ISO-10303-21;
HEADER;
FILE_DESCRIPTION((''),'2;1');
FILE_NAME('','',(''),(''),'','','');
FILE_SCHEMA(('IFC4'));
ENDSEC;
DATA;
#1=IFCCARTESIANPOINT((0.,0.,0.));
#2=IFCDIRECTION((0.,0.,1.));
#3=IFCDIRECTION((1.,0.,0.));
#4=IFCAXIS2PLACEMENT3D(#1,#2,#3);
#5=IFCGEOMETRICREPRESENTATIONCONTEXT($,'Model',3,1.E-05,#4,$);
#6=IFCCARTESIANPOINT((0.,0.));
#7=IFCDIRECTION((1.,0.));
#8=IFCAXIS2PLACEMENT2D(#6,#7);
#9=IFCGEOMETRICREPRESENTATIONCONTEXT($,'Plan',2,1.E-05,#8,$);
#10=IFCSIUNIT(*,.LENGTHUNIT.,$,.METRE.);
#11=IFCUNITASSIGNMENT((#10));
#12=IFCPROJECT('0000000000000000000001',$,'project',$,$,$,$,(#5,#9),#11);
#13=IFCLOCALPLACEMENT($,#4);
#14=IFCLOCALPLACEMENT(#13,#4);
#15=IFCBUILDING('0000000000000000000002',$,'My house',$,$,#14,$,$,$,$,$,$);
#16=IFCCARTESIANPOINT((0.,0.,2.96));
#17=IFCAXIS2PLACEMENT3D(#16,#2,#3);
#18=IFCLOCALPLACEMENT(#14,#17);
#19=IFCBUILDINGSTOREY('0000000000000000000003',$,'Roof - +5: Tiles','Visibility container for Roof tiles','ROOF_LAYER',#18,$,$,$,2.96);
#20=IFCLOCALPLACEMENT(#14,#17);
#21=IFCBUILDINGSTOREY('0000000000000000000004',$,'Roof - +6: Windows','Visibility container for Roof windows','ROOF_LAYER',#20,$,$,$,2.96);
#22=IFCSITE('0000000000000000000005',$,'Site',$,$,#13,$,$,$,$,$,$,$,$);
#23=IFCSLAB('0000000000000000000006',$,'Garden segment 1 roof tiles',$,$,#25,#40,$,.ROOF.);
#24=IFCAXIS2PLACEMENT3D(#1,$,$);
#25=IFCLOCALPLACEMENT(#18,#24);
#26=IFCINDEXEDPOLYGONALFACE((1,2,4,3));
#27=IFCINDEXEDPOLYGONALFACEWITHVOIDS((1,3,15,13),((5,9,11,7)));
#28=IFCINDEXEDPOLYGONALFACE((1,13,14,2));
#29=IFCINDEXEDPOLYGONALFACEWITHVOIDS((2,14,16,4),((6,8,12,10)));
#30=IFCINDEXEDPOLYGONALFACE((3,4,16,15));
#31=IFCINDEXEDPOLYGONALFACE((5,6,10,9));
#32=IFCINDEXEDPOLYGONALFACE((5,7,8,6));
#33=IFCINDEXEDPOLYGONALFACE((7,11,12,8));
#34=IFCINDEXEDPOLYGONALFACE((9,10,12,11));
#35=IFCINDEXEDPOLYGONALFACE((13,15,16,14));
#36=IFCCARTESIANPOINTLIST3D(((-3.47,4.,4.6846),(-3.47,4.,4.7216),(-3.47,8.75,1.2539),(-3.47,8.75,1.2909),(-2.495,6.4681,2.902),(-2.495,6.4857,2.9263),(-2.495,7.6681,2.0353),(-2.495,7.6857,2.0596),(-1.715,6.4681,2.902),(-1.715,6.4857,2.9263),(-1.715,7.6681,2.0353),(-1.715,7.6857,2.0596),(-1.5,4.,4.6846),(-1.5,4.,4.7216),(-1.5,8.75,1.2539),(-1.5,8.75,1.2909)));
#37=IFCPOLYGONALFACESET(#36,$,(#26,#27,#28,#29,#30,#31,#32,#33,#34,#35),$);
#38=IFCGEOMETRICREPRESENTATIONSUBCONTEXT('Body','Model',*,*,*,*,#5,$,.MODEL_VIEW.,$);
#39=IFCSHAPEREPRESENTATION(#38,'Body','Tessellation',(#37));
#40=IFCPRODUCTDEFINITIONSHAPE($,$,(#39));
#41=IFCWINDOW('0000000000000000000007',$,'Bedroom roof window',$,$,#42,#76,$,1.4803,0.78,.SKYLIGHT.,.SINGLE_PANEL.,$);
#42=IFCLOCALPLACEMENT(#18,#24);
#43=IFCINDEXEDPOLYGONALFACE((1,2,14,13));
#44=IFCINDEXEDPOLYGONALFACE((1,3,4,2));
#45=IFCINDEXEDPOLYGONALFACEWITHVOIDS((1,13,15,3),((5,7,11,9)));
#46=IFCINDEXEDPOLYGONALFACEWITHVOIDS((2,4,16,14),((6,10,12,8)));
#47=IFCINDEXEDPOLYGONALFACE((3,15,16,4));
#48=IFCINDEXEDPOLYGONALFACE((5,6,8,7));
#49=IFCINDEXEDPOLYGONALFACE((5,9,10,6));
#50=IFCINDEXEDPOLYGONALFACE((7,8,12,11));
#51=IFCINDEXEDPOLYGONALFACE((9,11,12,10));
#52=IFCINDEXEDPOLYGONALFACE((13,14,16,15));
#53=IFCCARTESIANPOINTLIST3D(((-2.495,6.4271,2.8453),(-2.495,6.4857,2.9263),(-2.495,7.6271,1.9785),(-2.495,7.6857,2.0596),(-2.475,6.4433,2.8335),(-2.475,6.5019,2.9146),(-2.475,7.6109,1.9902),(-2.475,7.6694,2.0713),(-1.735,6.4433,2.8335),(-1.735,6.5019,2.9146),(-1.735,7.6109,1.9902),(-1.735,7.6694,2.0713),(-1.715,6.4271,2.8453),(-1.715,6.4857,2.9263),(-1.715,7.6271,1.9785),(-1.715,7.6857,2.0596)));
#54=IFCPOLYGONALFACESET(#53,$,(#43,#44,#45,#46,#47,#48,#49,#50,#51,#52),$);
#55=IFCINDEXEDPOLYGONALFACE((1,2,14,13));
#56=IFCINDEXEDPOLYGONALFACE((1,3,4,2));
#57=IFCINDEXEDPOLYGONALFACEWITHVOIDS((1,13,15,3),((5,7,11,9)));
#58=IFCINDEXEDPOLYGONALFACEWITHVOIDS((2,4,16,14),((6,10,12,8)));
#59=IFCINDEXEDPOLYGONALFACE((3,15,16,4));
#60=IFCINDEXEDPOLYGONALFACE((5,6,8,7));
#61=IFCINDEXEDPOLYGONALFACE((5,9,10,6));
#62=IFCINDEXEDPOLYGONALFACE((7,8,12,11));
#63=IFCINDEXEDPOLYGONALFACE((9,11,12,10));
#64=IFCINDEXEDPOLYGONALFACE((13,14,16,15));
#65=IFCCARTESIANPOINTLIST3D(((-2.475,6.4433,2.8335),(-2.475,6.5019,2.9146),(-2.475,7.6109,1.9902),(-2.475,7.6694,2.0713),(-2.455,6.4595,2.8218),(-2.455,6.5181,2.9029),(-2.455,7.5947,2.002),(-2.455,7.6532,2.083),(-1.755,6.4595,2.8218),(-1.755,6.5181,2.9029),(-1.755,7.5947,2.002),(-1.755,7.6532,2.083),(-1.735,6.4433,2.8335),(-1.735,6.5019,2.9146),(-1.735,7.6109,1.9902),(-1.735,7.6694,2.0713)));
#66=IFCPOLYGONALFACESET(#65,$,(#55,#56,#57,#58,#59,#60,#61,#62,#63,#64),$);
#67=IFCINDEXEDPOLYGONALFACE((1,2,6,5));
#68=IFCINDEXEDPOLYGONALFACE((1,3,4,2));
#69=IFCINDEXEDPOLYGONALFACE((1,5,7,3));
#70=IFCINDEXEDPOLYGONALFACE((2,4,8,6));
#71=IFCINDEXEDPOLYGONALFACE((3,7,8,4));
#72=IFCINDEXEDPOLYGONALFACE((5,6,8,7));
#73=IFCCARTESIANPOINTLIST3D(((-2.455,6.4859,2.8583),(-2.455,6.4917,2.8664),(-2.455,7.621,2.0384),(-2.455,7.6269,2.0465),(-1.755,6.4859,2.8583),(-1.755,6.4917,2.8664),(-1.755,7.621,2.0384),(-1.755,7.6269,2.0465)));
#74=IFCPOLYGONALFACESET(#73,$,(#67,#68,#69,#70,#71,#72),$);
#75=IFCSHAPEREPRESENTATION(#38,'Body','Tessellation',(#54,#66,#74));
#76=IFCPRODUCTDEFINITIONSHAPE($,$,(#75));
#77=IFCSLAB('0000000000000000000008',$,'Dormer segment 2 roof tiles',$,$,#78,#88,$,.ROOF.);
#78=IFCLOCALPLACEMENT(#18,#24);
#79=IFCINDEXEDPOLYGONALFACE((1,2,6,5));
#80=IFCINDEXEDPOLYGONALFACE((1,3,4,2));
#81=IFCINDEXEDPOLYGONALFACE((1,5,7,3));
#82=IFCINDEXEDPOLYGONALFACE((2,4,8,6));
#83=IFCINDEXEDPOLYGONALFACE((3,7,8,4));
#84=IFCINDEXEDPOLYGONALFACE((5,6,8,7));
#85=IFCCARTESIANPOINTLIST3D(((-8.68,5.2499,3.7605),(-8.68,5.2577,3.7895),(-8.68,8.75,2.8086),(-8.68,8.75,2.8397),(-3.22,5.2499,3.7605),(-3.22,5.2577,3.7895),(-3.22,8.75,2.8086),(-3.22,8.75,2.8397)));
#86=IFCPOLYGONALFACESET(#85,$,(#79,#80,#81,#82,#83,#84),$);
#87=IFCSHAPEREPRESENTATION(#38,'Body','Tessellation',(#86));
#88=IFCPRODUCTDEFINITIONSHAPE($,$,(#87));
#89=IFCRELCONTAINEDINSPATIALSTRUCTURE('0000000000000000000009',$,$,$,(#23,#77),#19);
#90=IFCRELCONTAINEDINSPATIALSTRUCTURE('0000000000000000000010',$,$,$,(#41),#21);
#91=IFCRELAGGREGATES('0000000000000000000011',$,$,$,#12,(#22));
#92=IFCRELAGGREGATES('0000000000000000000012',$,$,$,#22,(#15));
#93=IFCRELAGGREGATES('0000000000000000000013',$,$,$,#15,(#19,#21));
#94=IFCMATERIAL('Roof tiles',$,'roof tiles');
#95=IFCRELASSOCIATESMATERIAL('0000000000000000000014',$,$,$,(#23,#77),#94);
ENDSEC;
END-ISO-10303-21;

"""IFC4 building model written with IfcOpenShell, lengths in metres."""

from ifc_helpers import new_model, si_unit, frame, origin_with_axes, origin_2d_with_axis, place, context, subcontext, project, spatial, line, indexed_curve, outline, extrude, clip, halfspace, source, transform, mapped, material, element, fill, save


model = new_model("IFC4")

# Units and contexts
model_context = context("Model", 3, precision=1e-05, world=origin_with_axes())
plan_context = context("Plan", 2, precision=1e-05, world=origin_2d_with_axis())
body_context = subcontext(model_context, "Body", "Model", "MODEL_VIEW")
ifc_project = project(units=[si_unit("LENGTHUNIT", "METRE")], contexts=[model_context, plan_context])

# Site, building, storey
site_placement = place(None, origin_with_axes())
site = spatial("IfcSite", under=ifc_project, at=site_placement, Name="Site")
building_placement = place(site_placement, origin_with_axes())
building = spatial("IfcBuilding", under=site, at=building_placement, Name="My house")
storey_1_placement = place(building_placement, frame((0.0, 0.0, 2.96), z_axis=(0.0, 0.0, 1.0), x_axis=(1.0, 0.0, 0.0)))
storey_1 = spatial("IfcBuildingStorey", under=building, at=storey_1_placement, Name="Roof - +5: Tiles", Description="Visibility container for Roof tiles", ObjectType="ROOF_LAYER", Elevation=2.96)

# Shared definitions
ifc_material = material(Name="Roof tiles", Category="roof tiles")

# Slab, opening
shared_shape_1 = source(origin_with_axes(), body_context, "Body", "Clipping", [
    clip(clip(extrude(outline(indexed_curve([(1.5, -3.0), (3.47, -3.0), (3.47, 10.0), (1.5, 10.0)])), None, (0.0, 0.0, 1.0), 0.03), halfspace(frame((0.0, 2.8266, -6.1972), z_axis=(0.0, -0.810664, -0.585512), x_axis=(-1.0, 0.0, 0.0)), False)), halfspace(frame((0.0, 6.6773, -3.416), z_axis=(0.0, 0.810664, 0.585512), x_axis=(1.0, 0.0, 0.0)), False)),
])
slab_1_placement = place(storey_1_placement, frame((0.0, 5.3371, 3.7189), z_axis=(0.0, 0.585512, 0.810664), x_axis=(1.0, 0.0, 0.0)))
slab_1 = element("IfcSlab", 1, at=slab_1_placement, inside=storey_1, material=ifc_material, Name="Garden segment 1 roof tiles", PredefinedType="ROOF", context=body_context, shape_type="MappedRepresentation", body=[
    mapped(shared_shape_1, transform((0.0, 0.0, 0.0), x_axis=(-1.0, 0.0, 0.0), y_axis=(0.0, 1.0, 0.0), z_axis=(0.0, 0.0, 1.0), scale=1.0)),
])
shared_shape_2 = source(origin_with_axes(), body_context, "Body", "SweptSolid", [
    extrude(outline(indexed_curve([(1.715, 1.3952), (2.495, 1.3952), (2.495, 2.8754), (1.715, 2.8754)])), None, (0.0, 0.0, 1.0), 0.13),
])
opening_placement = place(slab_1_placement, frame((0.0, 0.0, -0.05), z_axis=(0.0, 0.0, 1.0), x_axis=(1.0, 0.0, 0.0)))
opening = element("IfcOpeningElement", 2, at=opening_placement, cuts=slab_1, ObjectType="ROOF_OPENING", PredefinedType="OPENING", context=body_context, shape_type="MappedRepresentation", body=[
    mapped(shared_shape_2, transform((0.0, 0.0, 0.0), x_axis=(-1.0, 0.0, 0.0), y_axis=(0.0, 1.0, 0.0), z_axis=(0.0, 0.0, 1.0), scale=1.0)),
])

# Shared definitions
storey_2_placement = place(building_placement, frame((0.0, 0.0, 2.96), z_axis=(0.0, 0.0, 1.0), x_axis=(1.0, 0.0, 0.0)))
storey_2 = spatial("IfcBuildingStorey", under=building, at=storey_2_placement, Name="Roof - +6: Windows", Description="Visibility container for Roof windows", ObjectType="ROOF_LAYER", Elevation=2.96)

# Window
shared_shape_3 = source(origin_with_axes(), body_context, "Body", "SweptSolid", [
    extrude(outline(indexed_curve([(0.0, 0.0), (0.78, 0.0), (0.78, 1.4803), (0.0, 1.4803)], segments=[line(1, 2, 3, 4, 1)]), holes=[indexed_curve([(0.02, 0.02), (0.76, 0.02), (0.76, 1.4603), (0.02, 1.4603)], segments=[line(1, 2, 3, 4, 1)])]), frame((0.0, 0.0, 0.0), z_axis=(0.0, -1.0, 0.0), x_axis=(1.0, 0.0, 0.0)), (0.0, 0.0, -1.0), 0.1),
    extrude(outline(indexed_curve([(0.0, 0.0), (0.74, 0.0), (0.74, 1.4403), (0.0, 1.4403)], segments=[line(1, 2, 3, 4, 1)]), holes=[indexed_curve([(0.02, 0.02), (0.72, 0.02), (0.72, 1.4203), (0.02, 1.4203)], segments=[line(1, 2, 3, 4, 1)])]), frame((0.02, 0.0, 0.02), z_axis=(0.0, -1.0, 0.0), x_axis=(1.0, 0.0, 0.0)), (0.0, 0.0, -1.0), 0.1),
    extrude(outline(indexed_curve([(0.02, 0.02), (0.72, 0.02), (0.72, 1.4203), (0.02, 1.4203)], segments=[line(1, 2, 3, 4, 1)])), frame((0.02, 0.045, 0.02), z_axis=(0.0, -1.0, 0.0), x_axis=(1.0, 0.0, 0.0)), (0.0, 0.0, -1.0), 0.01),
])
window_placement = place(opening_placement, frame((-1.715, 1.3952, 0.08), z_axis=(0.0, 1.0, 0.0), x_axis=(1.0, 0.0, 0.0)))
window = element("IfcWindow", 3, at=window_placement, inside=storey_2, Name="Bedroom roof window", OverallHeight=1.4803, OverallWidth=0.78, PartitioningType="SINGLE_PANEL", PredefinedType="SKYLIGHT", context=body_context, shape_type="MappedRepresentation", body=[
    mapped(shared_shape_3, transform((0.0, 0.0, 0.0), x_axis=(-1.0, 0.0, 0.0), y_axis=(0.0, 1.0, 0.0), z_axis=(0.0, 0.0, 1.0), scale=1.0)),
])
fill(opening, window)

# Slab
shared_shape_4 = source(origin_with_axes(), body_context, "Body", "Clipping", [
    clip(clip(extrude(outline(indexed_curve([(3.22, 0.0), (8.68, 0.0), (8.68, 7.0), (3.22, 7.0)])), None, (0.0, 0.0, 1.0), 0.03), halfspace(frame((0.0, 0.5577, -6.813), z_axis=(0.0, -0.964948, -0.262441), x_axis=(-1.0, 0.0, 0.0)), False)), halfspace(frame((0.0, 5.1412, -5.5664), z_axis=(0.0, 0.964948, 0.262441), x_axis=(1.0, 0.0, 0.0)), False)),
])
slab_2_placement = place(storey_1_placement, frame((0.0, 5.2499, 3.7605), z_axis=(0.0, 0.262441, 0.964948), x_axis=(1.0, 0.0, 0.0)))
element("IfcSlab", 4, at=slab_2_placement, inside=storey_1, material=ifc_material, Name="Dormer segment 2 roof tiles", PredefinedType="ROOF", context=body_context, shape_type="MappedRepresentation", body=[
    mapped(shared_shape_4, transform((0.0, 0.0, 0.0), x_axis=(-1.0, 0.0, 0.0), y_axis=(0.0, 1.0, 0.0), z_axis=(0.0, 0.0, 1.0), scale=1.0)),
])

save(model, "model.ifc")
